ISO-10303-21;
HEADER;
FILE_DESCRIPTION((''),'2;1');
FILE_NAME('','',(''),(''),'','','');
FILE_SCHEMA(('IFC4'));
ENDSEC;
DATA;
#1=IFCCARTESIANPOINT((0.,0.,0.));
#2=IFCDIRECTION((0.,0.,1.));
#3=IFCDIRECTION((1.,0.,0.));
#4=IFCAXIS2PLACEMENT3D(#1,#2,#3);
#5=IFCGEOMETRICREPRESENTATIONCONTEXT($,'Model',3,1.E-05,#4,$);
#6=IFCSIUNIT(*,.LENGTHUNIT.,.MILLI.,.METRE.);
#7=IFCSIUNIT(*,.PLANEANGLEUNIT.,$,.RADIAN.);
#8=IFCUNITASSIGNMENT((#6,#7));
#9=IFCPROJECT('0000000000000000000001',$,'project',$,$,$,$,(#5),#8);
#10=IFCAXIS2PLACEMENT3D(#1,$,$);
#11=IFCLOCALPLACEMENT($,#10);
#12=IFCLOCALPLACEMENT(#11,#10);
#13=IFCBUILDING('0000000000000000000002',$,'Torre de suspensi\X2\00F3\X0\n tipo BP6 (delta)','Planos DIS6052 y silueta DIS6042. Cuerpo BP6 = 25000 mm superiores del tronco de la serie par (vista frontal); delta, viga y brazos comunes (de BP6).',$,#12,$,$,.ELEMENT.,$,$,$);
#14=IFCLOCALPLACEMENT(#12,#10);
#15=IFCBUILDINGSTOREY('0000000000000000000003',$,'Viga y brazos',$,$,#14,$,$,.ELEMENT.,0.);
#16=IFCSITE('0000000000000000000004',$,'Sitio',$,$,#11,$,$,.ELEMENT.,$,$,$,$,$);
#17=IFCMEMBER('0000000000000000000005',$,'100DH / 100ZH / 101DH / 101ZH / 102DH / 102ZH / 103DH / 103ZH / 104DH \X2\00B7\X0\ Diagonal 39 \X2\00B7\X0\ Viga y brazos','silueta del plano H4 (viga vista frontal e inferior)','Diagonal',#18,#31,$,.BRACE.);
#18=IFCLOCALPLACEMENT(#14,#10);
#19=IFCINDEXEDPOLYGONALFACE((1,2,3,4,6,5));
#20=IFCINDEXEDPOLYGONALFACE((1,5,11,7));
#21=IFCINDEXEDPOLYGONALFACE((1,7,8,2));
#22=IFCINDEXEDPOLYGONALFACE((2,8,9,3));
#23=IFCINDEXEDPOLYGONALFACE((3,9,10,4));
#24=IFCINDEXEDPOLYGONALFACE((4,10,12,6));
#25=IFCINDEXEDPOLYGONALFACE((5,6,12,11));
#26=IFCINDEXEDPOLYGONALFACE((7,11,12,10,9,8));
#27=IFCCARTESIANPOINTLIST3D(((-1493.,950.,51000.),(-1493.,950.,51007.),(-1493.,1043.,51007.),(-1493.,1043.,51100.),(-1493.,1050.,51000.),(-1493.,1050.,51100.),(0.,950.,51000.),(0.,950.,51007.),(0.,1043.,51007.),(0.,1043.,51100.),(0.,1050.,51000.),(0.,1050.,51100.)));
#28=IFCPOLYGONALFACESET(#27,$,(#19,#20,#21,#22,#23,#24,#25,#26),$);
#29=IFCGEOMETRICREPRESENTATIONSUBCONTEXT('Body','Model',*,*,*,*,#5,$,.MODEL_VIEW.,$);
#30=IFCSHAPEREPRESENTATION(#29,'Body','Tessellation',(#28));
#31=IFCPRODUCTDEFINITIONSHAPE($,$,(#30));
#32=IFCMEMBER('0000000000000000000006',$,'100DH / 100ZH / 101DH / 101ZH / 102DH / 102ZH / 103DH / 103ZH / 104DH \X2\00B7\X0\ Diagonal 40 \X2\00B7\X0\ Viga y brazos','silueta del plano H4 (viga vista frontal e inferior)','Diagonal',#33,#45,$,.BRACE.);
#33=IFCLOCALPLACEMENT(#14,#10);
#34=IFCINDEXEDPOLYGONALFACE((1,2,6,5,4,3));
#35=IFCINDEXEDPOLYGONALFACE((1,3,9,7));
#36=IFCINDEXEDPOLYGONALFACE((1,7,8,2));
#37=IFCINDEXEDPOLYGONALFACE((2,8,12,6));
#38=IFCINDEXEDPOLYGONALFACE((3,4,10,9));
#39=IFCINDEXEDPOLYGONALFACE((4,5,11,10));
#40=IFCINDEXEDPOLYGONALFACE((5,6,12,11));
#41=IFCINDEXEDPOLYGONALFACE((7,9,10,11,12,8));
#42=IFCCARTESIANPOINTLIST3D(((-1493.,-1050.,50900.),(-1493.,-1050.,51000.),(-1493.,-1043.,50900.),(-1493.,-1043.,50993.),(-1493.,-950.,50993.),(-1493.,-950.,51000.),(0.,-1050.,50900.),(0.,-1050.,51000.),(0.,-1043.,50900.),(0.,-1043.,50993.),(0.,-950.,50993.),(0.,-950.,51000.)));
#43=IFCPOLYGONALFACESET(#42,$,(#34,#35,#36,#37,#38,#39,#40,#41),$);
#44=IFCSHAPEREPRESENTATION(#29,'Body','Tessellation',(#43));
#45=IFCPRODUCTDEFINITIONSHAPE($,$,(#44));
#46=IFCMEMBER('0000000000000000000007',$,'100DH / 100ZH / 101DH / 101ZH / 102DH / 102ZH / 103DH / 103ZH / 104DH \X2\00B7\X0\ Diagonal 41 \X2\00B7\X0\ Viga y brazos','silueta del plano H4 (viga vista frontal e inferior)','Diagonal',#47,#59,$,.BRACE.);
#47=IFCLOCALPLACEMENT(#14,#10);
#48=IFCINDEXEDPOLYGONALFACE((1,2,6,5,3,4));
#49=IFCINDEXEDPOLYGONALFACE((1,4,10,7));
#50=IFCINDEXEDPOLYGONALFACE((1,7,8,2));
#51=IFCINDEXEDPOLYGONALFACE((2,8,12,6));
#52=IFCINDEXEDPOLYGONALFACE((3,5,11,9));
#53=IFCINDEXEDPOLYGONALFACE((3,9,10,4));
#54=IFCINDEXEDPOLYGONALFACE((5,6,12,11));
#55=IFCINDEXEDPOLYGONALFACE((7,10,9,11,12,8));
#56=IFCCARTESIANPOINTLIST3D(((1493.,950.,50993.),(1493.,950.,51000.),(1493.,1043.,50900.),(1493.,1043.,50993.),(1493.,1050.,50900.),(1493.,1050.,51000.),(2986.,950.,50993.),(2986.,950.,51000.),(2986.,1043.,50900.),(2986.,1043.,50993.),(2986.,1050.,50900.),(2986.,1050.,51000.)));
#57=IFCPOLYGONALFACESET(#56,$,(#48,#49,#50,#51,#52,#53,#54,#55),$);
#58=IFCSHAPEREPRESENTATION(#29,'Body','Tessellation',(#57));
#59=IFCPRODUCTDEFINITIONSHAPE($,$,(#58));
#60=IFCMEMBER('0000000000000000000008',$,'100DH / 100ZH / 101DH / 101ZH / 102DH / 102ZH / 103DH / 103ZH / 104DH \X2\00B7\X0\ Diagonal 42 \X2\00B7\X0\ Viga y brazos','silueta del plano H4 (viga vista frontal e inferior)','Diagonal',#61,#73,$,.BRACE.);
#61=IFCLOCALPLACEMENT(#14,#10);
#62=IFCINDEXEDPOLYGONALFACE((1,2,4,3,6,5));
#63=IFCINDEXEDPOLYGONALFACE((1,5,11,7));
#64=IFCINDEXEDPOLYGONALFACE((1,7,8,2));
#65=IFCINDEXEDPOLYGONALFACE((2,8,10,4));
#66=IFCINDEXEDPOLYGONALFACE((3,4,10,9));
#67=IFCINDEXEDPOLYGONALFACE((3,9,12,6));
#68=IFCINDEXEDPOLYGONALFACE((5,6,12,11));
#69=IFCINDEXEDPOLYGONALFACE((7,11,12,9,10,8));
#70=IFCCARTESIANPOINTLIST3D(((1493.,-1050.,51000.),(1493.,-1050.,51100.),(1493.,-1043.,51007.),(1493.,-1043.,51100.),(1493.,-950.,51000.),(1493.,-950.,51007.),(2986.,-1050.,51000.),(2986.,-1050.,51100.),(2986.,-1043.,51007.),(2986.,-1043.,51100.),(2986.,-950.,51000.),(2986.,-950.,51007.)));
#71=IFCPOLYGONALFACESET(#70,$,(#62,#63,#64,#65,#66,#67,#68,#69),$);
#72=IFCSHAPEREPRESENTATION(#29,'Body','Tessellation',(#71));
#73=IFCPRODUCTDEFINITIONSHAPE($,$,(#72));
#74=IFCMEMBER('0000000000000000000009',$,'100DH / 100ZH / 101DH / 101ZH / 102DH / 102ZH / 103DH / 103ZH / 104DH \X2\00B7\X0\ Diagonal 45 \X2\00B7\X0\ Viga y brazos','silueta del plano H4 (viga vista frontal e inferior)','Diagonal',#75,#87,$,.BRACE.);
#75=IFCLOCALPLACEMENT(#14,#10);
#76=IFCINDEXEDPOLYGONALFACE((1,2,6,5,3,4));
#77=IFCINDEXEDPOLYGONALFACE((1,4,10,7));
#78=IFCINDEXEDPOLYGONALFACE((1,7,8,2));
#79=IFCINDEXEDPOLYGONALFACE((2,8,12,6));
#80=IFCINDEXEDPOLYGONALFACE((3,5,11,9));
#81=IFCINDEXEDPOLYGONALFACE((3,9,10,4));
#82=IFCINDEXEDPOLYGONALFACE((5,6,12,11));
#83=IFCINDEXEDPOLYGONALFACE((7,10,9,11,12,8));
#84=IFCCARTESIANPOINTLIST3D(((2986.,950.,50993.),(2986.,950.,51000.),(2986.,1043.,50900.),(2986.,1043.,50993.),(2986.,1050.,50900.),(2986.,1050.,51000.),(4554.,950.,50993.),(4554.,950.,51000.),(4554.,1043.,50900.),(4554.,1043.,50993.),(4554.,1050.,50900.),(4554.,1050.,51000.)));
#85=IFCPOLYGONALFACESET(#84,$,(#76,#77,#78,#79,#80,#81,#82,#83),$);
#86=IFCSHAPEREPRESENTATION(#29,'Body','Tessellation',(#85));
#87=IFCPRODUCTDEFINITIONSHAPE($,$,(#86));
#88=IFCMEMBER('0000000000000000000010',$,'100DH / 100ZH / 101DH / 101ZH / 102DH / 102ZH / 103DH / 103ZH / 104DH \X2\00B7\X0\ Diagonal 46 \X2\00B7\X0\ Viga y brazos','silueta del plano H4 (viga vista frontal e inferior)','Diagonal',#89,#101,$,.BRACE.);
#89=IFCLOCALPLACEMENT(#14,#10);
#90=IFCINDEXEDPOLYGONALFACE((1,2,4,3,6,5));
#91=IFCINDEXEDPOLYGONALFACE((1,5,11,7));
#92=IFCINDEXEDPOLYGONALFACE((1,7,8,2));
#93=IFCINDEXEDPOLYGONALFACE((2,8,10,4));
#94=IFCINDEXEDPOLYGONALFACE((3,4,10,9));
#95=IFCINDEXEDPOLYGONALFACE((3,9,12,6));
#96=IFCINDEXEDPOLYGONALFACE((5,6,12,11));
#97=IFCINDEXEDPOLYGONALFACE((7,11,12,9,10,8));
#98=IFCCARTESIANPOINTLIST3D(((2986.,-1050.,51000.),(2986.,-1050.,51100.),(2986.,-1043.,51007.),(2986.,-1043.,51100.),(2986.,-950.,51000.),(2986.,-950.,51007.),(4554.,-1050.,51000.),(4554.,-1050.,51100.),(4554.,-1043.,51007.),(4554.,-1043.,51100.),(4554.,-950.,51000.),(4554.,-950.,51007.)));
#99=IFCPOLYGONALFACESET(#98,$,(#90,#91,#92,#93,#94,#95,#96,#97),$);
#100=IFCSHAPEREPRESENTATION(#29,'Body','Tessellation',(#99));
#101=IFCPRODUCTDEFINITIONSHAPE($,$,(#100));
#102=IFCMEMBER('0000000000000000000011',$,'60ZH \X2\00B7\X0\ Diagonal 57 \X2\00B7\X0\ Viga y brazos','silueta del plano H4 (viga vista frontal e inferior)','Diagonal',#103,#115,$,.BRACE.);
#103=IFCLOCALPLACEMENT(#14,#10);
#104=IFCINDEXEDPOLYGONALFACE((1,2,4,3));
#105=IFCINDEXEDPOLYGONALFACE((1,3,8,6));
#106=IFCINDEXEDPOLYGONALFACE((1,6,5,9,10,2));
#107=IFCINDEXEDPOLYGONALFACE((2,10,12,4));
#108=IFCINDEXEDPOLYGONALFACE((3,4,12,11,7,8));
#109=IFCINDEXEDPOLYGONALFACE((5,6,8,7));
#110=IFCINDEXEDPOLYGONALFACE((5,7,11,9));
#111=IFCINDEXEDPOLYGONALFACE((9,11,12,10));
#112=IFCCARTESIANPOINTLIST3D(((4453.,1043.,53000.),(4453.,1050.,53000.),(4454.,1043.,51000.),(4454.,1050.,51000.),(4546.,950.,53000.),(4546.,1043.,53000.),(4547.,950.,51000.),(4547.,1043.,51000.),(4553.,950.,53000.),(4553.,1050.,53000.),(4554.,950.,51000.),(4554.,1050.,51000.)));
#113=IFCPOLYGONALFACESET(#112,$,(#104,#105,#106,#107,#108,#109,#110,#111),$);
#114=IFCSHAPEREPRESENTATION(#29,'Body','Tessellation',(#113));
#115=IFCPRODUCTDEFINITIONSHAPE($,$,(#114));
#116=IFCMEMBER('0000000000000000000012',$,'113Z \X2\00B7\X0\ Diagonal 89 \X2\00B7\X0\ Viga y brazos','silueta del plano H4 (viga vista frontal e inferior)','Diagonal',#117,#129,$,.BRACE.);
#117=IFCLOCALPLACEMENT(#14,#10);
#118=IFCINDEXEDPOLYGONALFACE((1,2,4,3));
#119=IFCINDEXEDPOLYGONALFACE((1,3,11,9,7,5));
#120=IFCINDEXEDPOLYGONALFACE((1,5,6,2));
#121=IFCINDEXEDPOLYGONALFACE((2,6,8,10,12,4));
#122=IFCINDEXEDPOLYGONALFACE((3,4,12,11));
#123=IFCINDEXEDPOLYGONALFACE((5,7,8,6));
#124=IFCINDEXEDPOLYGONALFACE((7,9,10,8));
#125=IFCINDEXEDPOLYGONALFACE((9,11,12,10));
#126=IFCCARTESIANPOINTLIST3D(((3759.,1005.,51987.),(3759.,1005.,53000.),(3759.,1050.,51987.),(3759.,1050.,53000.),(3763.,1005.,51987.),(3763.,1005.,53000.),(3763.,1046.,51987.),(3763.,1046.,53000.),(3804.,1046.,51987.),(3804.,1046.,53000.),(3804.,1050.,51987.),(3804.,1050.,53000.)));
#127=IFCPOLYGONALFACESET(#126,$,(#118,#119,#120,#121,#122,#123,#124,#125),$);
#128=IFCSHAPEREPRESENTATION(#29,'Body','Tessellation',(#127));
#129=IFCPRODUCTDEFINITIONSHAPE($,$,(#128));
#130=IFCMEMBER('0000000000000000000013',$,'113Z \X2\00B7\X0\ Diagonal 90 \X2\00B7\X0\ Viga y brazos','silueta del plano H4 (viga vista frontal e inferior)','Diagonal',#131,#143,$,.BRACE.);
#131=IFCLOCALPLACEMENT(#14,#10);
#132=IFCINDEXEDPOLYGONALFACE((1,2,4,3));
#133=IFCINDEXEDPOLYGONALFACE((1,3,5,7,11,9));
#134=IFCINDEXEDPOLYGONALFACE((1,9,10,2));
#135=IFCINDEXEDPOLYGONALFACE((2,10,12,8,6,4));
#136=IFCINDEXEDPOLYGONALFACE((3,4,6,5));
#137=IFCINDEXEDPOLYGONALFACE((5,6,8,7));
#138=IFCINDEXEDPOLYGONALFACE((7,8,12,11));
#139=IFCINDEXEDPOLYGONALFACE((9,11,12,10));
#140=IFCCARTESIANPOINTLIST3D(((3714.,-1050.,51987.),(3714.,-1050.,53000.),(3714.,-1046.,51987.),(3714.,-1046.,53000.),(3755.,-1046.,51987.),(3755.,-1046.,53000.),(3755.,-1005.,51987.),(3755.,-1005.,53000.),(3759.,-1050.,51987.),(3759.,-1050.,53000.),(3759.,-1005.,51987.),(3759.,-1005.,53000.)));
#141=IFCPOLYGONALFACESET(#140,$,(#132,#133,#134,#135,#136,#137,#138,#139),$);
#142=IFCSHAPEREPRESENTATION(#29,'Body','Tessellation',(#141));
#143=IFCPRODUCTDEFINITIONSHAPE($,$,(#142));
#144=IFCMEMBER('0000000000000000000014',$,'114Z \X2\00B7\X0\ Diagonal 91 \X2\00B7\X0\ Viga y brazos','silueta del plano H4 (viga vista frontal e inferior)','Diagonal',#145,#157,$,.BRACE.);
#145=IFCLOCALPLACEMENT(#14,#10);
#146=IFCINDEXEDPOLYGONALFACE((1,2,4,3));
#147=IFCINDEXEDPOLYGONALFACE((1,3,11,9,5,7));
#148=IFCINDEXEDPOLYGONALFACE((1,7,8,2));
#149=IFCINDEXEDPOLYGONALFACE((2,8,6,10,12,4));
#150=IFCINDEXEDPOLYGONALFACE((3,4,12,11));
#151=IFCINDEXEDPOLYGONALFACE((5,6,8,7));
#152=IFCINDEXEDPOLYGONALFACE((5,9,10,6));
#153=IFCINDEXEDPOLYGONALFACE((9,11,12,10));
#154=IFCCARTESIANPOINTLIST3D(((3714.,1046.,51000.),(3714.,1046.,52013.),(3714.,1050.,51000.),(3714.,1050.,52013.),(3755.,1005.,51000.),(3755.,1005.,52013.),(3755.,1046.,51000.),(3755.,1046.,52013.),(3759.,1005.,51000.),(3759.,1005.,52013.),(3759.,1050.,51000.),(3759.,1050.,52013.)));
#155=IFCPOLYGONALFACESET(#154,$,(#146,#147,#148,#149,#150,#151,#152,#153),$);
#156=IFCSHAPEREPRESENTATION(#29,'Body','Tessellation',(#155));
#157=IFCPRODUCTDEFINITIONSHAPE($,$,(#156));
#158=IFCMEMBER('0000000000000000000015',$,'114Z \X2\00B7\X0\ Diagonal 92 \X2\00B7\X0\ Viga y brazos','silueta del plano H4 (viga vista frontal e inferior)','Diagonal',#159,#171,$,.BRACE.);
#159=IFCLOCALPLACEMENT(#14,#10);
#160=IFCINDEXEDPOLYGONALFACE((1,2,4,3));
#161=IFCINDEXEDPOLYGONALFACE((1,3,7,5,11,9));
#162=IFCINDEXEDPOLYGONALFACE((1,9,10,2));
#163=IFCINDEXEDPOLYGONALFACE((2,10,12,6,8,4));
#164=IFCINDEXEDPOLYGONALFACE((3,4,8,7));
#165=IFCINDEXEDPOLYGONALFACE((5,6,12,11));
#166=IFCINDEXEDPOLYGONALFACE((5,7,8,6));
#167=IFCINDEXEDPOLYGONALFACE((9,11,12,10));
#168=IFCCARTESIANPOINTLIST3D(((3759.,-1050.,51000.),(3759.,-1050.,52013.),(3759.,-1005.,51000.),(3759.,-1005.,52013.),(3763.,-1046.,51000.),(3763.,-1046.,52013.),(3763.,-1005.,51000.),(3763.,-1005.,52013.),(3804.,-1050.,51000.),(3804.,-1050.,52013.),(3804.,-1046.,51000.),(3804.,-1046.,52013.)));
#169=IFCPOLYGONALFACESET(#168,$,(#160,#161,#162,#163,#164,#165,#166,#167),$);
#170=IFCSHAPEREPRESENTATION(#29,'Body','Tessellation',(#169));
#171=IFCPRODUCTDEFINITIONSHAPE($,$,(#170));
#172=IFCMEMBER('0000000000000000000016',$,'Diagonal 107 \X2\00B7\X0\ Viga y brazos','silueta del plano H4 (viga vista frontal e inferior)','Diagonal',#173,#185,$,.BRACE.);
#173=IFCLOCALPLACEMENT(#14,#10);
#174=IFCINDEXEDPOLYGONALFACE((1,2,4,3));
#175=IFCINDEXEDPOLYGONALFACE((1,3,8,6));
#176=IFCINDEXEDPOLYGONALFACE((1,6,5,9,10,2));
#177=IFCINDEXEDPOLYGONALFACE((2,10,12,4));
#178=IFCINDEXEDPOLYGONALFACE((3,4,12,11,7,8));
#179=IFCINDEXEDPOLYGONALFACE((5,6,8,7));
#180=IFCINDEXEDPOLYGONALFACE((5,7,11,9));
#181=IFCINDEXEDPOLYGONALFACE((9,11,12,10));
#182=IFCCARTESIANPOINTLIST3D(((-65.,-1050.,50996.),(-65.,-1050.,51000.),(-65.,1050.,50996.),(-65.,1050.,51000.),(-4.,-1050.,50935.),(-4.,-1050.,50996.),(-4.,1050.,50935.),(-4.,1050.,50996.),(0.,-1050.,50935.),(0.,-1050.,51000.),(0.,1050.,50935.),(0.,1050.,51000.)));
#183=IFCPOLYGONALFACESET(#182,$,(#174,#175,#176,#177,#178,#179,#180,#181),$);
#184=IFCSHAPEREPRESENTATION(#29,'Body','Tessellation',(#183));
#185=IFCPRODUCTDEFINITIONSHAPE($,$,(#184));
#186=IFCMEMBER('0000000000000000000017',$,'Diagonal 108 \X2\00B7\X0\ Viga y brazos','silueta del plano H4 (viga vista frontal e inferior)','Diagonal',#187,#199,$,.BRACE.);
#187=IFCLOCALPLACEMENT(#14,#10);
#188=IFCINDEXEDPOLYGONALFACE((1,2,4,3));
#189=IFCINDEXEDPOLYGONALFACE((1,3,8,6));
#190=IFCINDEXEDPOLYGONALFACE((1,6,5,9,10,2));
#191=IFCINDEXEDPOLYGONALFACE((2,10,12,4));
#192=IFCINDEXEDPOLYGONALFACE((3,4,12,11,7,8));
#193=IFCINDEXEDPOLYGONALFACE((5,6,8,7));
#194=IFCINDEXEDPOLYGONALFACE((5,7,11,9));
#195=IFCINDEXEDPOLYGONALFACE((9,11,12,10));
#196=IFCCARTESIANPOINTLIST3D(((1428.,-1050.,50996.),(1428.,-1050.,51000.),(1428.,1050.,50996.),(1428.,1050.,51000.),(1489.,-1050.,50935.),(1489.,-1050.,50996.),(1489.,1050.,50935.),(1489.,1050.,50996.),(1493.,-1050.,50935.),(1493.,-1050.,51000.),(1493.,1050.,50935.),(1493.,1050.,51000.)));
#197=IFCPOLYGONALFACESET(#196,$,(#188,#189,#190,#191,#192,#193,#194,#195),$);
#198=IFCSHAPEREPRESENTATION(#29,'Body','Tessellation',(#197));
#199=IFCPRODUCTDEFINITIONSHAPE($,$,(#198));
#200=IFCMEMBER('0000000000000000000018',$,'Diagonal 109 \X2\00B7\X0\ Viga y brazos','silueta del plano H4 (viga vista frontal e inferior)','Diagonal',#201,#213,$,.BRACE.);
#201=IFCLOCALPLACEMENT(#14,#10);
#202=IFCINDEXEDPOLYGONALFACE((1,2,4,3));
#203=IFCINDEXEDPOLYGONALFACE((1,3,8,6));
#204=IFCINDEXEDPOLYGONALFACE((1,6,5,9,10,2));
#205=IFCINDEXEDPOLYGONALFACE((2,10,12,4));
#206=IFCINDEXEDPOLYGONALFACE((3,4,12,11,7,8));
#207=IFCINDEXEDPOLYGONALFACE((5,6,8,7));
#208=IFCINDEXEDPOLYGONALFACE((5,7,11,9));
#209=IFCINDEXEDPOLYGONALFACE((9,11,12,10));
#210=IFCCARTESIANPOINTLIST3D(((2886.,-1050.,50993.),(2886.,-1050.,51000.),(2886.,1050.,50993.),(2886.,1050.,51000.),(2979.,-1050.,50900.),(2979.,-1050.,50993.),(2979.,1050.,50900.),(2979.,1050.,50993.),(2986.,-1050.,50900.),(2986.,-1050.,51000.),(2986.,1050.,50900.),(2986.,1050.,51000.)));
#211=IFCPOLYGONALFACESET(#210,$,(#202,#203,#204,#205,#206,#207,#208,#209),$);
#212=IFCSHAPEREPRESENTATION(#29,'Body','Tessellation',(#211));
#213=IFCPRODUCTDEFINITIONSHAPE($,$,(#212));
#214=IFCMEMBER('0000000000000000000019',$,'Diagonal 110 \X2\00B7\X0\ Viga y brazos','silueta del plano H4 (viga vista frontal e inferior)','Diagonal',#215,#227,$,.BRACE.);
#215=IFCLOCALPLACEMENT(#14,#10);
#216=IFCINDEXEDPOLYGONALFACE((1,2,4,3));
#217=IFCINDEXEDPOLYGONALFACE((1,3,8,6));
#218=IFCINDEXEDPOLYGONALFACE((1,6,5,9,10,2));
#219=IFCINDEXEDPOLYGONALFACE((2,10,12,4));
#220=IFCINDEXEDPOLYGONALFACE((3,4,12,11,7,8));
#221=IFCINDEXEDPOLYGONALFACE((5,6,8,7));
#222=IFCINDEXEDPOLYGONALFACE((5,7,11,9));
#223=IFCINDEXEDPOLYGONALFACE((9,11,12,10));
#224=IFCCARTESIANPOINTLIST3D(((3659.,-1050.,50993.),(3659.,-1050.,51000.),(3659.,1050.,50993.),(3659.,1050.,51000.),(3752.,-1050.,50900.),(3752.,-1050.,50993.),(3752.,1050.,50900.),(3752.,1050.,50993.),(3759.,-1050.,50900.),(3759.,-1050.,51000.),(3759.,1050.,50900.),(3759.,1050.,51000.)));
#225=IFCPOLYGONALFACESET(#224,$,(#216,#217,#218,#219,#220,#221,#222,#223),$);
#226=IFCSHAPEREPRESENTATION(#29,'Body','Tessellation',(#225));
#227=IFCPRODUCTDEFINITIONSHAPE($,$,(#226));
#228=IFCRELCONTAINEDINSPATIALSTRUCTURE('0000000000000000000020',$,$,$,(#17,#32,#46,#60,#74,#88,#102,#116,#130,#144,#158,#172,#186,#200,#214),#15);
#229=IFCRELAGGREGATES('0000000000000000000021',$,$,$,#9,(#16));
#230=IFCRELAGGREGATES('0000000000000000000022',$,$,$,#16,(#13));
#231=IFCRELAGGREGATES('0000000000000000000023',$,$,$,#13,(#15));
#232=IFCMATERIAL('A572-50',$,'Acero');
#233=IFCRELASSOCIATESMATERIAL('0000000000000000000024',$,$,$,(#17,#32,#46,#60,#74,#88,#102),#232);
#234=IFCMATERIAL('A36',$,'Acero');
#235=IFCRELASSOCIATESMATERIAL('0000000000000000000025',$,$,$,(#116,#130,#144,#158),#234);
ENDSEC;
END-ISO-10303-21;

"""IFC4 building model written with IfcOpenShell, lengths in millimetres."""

from ifc_helpers import new_model, si_unit, frame, frame_2d, origin, origin_with_axes, place, context, subcontext, project, spatial, l_section, extrude, material, element, save


model = new_model("IFC4")

# Units and contexts
model_context = context("Model", 3, precision=1e-05, world=origin_with_axes())
body_context = subcontext(model_context, "Body", "Model", "MODEL_VIEW")
ifc_project = project(units=[si_unit("LENGTHUNIT", "METRE", prefix="MILLI"), si_unit("PLANEANGLEUNIT", "RADIAN")], contexts=[model_context])

# Site, building, storey
site_placement = place(None, origin())
site = spatial("IfcSite", under=ifc_project, at=site_placement, Name="Sitio", CompositionType="ELEMENT")
building_placement = place(site_placement, origin())
building = spatial("IfcBuilding", under=site, at=building_placement, Name="Torre de suspensión tipo BP6 (delta)", Description="Planos DIS6052 y silueta DIS6042. Cuerpo BP6 = 25000 mm superiores del tronco de la serie par (vista frontal); delta, viga y brazos comunes (de BP6).", CompositionType="ELEMENT")
storey_placement = place(building_placement, origin())
storey = spatial("IfcBuildingStorey", under=building, at=storey_placement, Name="Viga y brazos", CompositionType="ELEMENT", Elevation=0.0)

# Members
ifc_material_1 = material(Name="A572-50", Category="Acero")
ifc_material_2 = material(Name="A36", Category="Acero")
for number, where, z_axis, x_axis, name in (
    (1, (0.0, 1050.0, 51000.0), (-1.0, 0.0, 0.0), (0.0, -1.0, 0.0), "100DH / 100ZH / 101DH / 101ZH / 102DH / 102ZH / 103DH / 103ZH / 104DH · Diagonal 39 · Viga y brazos"),
    (2, (0.0, -1050.0, 51000.0), (-1.0, 0.0, 0.0), (0.0, 1.0, 0.0), "100DH / 100ZH / 101DH / 101ZH / 102DH / 102ZH / 103DH / 103ZH / 104DH · Diagonal 40 · Viga y brazos"),
    (3, (1493.0, 1050.0, 51000.0), (1.0, 0.0, 0.0), (0.0, -1.0, 0.0), "100DH / 100ZH / 101DH / 101ZH / 102DH / 102ZH / 103DH / 103ZH / 104DH · Diagonal 41 · Viga y brazos"),
    (4, (1493.0, -1050.0, 51000.0), (1.0, 0.0, 0.0), (0.0, 1.0, 0.0), "100DH / 100ZH / 101DH / 101ZH / 102DH / 102ZH / 103DH / 103ZH / 104DH · Diagonal 42 · Viga y brazos"),
):
    element("IfcMember", number, at=place(storey_placement, frame(where, z_axis=z_axis, x_axis=x_axis)), inside=storey, material=ifc_material_1, Name=name, Description="silueta del plano H4 (viga vista frontal e inferior)", ObjectType="Diagonal", PredefinedType="BRACE", context=body_context, shape_type="SweptSolid", body=[
        extrude(l_section(Depth=100.0, Width=100.0, Thickness=7.0, at=frame_2d((50.0, 50.0))), None, (0.0, 0.0, 1.0), 1493.0),
    ])
for number, where, z_axis, x_axis, name in (
    (5, (2986.0, 1050.0, 51000.0), (1.0, 0.0, 0.0), (0.0, -1.0, 0.0), "100DH / 100ZH / 101DH / 101ZH / 102DH / 102ZH / 103DH / 103ZH / 104DH · Diagonal 45 · Viga y brazos"),
    (6, (2986.0, -1050.0, 51000.0), (1.0, 0.0, 0.0), (0.0, 1.0, 0.0), "100DH / 100ZH / 101DH / 101ZH / 102DH / 102ZH / 103DH / 103ZH / 104DH · Diagonal 46 · Viga y brazos"),
):
    element("IfcMember", number, at=place(storey_placement, frame(where, z_axis=z_axis, x_axis=x_axis)), inside=storey, material=ifc_material_1, Name=name, Description="silueta del plano H4 (viga vista frontal e inferior)", ObjectType="Diagonal", PredefinedType="BRACE", context=body_context, shape_type="SweptSolid", body=[
        extrude(l_section(Depth=100.0, Width=100.0, Thickness=7.0, at=frame_2d((50.0, 50.0))), None, (0.0, 0.0, 1.0), 1568.0),
    ])
member_placement = place(storey_placement, frame((4553.0, 1050.0, 53000.0), z_axis=(0.0005, 0.0, -1.0), x_axis=(0.0, -1.0, 0.0)))
element("IfcMember", 7, at=member_placement, inside=storey, material=ifc_material_1, Name="60ZH · Diagonal 57 · Viga y brazos", Description="silueta del plano H4 (viga vista frontal e inferior)", ObjectType="Diagonal", PredefinedType="BRACE", context=body_context, shape_type="SweptSolid", body=[
    extrude(l_section(Depth=100.0, Width=100.0, Thickness=7.0, at=frame_2d((50.0, 50.0))), None, (0.0, 0.0, 1.0), 2000.0),
])
for number, where, z_axis, x_axis, name in (
    (8, (3759.0, 1050.0, 51987.0), (0.0, 0.0, 1.0), (0.0, -1.0, 0.0), "113Z · Diagonal 89 · Viga y brazos"),
    (9, (3759.0, -1050.0, 51987.0), (0.0, 0.0, 1.0), (0.0, 1.0, 0.0), "113Z · Diagonal 90 · Viga y brazos"),
    (10, (3759.0, 1050.0, 52013.0), (0.0, 0.0, -1.0), (0.0, -1.0, 0.0), "114Z · Diagonal 91 · Viga y brazos"),
    (11, (3759.0, -1050.0, 52013.0), (0.0, 0.0, -1.0), (0.0, 1.0, 0.0), "114Z · Diagonal 92 · Viga y brazos"),
):
    element("IfcMember", number, at=place(storey_placement, frame(where, z_axis=z_axis, x_axis=x_axis)), inside=storey, material=ifc_material_2, Name=name, Description="silueta del plano H4 (viga vista frontal e inferior)", ObjectType="Diagonal", PredefinedType="BRACE", context=body_context, shape_type="SweptSolid", body=[
        extrude(l_section(Depth=45.0, Width=45.0, Thickness=4.0, at=frame_2d((22.5, 22.5))), None, (0.0, 0.0, 1.0), 1013.0),
    ])
for number, where, z_axis, x_axis, name in (
    (12, (0.0, 1050.0, 51000.0), (0.0, -1.0, 0.0), (-1.0, 0.0, 0.0), "Diagonal 107 · Viga y brazos"),
    (13, (1493.0, 1050.0, 51000.0), (0.0, -1.0, 0.0), (-1.0, 0.0, 0.0), "Diagonal 108 · Viga y brazos"),
):
    element("IfcMember", number, at=place(storey_placement, frame(where, z_axis=z_axis, x_axis=x_axis)), inside=storey, Name=name, Description="silueta del plano H4 (viga vista frontal e inferior)", ObjectType="Diagonal", PredefinedType="BRACE", context=body_context, shape_type="SweptSolid", body=[
        extrude(l_section(Depth=65.0, Width=65.0, Thickness=4.0, at=frame_2d((32.5, 32.5))), None, (0.0, 0.0, 1.0), 2100.0),
    ])
for number, where, z_axis, x_axis, name in (
    (14, (2986.0, 1050.0, 51000.0), (0.0, -1.0, 0.0), (-1.0, 0.0, 0.0), "Diagonal 109 · Viga y brazos"),
    (15, (3759.0, 1050.0, 51000.0), (0.0, -1.0, 0.0), (-1.0, 0.0, 0.0), "Diagonal 110 · Viga y brazos"),
):
    element("IfcMember", number, at=place(storey_placement, frame(where, z_axis=z_axis, x_axis=x_axis)), inside=storey, Name=name, Description="silueta del plano H4 (viga vista frontal e inferior)", ObjectType="Diagonal", PredefinedType="BRACE", context=body_context, shape_type="SweptSolid", body=[
        extrude(l_section(Depth=100.0, Width=100.0, Thickness=7.0, at=frame_2d((50.0, 50.0))), None, (0.0, 0.0, 1.0), 2100.0),
    ])

save(model, "model.ifc")
